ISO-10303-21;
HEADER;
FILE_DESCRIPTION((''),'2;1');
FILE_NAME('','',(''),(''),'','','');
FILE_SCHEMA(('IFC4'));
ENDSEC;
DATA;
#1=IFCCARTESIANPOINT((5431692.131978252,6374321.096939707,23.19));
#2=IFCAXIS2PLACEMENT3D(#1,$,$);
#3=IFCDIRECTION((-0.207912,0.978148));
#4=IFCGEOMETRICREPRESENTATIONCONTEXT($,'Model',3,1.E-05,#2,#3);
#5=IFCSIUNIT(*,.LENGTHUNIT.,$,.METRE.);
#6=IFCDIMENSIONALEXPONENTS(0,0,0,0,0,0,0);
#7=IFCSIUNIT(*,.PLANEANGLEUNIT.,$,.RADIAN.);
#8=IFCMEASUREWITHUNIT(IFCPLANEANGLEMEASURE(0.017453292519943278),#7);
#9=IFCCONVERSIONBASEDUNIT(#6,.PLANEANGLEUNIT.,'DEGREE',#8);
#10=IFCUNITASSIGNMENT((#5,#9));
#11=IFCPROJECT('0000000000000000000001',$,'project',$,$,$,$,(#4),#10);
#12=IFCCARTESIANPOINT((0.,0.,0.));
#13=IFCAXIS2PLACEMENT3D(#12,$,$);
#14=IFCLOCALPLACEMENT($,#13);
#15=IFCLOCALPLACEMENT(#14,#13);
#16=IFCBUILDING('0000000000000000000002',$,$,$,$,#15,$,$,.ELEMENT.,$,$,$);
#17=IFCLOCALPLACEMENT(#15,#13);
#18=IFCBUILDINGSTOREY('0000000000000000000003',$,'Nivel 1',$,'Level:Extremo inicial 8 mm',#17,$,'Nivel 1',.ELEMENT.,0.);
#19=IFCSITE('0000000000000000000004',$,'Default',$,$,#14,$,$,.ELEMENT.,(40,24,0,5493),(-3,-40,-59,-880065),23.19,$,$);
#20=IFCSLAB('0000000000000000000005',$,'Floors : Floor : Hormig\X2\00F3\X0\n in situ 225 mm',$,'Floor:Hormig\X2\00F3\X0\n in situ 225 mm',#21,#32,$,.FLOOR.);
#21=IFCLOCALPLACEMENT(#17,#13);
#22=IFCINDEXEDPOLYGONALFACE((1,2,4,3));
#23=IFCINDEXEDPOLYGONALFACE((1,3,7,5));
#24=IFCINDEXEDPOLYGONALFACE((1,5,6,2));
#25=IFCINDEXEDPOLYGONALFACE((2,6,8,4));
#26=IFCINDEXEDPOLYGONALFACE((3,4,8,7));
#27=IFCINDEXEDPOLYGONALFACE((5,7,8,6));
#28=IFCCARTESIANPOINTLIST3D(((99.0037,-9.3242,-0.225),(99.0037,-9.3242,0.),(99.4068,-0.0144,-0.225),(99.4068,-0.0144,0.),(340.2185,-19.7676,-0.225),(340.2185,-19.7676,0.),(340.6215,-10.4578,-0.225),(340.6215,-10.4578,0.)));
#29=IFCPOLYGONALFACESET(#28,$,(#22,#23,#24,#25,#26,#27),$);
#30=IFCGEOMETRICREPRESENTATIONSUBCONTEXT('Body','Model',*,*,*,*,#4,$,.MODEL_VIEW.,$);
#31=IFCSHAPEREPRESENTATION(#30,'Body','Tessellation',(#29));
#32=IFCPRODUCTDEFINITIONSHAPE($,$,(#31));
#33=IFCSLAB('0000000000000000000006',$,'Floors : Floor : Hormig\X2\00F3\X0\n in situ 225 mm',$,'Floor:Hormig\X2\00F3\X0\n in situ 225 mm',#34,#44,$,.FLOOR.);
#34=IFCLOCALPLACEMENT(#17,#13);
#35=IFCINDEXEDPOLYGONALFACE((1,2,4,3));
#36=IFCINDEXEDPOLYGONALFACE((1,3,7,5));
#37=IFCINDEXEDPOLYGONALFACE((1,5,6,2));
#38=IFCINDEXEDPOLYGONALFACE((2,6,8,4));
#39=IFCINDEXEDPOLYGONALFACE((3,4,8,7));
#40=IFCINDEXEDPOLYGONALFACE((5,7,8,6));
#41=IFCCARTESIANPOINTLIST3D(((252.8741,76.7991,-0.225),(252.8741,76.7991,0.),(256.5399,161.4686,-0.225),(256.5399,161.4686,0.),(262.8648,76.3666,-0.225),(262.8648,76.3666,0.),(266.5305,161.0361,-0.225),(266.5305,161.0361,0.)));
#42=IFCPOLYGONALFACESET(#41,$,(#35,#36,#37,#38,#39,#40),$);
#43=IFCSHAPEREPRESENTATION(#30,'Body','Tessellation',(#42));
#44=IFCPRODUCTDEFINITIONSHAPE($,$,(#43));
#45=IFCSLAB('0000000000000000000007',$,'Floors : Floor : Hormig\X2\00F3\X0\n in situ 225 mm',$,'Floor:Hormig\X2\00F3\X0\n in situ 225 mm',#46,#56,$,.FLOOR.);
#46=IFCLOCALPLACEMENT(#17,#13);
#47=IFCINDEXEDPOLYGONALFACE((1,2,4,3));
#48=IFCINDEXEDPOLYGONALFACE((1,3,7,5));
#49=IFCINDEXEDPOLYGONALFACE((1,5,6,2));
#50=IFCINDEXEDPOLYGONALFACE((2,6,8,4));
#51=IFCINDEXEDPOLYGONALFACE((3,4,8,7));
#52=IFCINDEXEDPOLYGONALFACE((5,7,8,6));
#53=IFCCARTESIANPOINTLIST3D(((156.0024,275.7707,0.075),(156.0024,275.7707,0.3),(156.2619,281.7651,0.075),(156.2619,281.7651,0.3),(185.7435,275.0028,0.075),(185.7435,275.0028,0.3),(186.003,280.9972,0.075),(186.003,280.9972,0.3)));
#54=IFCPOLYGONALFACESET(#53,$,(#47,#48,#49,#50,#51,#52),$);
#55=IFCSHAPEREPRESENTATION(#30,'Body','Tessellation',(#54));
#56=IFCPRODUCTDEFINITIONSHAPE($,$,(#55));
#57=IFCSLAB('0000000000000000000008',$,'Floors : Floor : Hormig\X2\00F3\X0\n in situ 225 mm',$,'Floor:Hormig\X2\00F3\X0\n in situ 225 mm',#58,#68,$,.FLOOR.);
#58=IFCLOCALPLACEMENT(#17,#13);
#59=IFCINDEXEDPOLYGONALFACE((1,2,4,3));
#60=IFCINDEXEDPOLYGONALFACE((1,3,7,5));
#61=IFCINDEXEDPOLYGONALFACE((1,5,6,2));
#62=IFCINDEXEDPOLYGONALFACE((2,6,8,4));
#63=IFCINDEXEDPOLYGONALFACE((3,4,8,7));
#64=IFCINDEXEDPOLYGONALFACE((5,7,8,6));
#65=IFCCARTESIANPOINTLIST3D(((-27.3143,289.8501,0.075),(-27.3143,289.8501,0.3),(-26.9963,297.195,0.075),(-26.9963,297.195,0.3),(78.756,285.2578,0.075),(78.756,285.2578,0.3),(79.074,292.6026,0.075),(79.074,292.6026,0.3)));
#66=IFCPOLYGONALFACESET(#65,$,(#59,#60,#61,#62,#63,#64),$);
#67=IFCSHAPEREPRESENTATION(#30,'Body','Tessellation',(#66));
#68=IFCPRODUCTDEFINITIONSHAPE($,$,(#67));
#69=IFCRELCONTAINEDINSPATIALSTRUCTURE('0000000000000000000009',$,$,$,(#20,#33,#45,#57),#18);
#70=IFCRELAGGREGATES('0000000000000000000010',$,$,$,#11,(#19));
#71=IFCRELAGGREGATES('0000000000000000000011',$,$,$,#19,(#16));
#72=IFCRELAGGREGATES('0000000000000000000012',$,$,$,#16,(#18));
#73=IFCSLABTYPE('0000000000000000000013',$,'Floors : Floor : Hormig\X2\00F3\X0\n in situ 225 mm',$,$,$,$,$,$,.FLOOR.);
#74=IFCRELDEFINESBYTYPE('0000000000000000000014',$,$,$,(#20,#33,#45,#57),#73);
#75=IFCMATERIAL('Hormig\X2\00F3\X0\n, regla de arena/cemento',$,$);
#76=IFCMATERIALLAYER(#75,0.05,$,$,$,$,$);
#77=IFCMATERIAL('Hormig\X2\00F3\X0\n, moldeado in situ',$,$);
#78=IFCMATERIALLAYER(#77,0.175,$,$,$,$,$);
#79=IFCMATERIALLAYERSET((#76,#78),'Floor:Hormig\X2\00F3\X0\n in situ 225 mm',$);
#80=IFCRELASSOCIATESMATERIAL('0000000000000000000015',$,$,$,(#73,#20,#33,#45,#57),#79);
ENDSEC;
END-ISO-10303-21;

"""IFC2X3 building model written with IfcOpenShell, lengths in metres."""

from ifc_helpers import new_model, entity, si_unit, converted_unit, direction, frame, frame_2d, origin, place, context, subcontext, project, spatial, polyline, rectangle, outline, extrude, material, layer, layer_set, layer_usage, type_object, element, save


model = new_model("IFC2X3")

# Units and contexts
model_context = context("Model", 3, precision=1e-05, world=frame((5431692.131978252, 6374321.096939707, 23.19)), true_north=direction((-0.207912, 0.978148)))
body_context = subcontext(model_context, "Body", "Model", "MODEL_VIEW")
ifc_project = project(units=[si_unit("LENGTHUNIT", "METRE"), converted_unit("PLANEANGLEUNIT", "DEGREE", entity("IfcPlaneAngleMeasure", 0.017453292519943278), si_unit("PLANEANGLEUNIT", "RADIAN"), dimensions=[0, 0, 0, 0, 0, 0, 0])], contexts=[model_context])

# Site, building, storey
site_placement = place(None, origin())
site = spatial("IfcSite", under=ifc_project, at=site_placement, Name="Default", CompositionType="ELEMENT", RefLatitude=(40, 24, 0, 5493), RefLongitude=(-3, -40, -59, -880065), RefElevation=23.19)
building_placement = place(site_placement, origin())
building = spatial("IfcBuilding", under=site, at=building_placement, CompositionType="ELEMENT")
storey_placement = place(building_placement, origin())
storey = spatial("IfcBuildingStorey", under=building, at=storey_placement, Name="Nivel 1", ObjectType="Level:Extremo inicial 8 mm", LongName="Nivel 1", CompositionType="ELEMENT", Elevation=0.0)

# Slabs
ifc_material_1 = material(Name="Hormigón, regla de arena/cemento")
ifc_layer_1 = layer(ifc_material_1, 0.05)
ifc_material_2 = material(Name="Hormigón, moldeado in situ")
ifc_layer_2 = layer(ifc_material_2, 0.175)
ifc_layer_set = layer_set([ifc_layer_1, ifc_layer_2], Name="Floor:Hormigón in situ 225 mm")
slab_type = type_object("IfcSlabType", Name="Floors : Floor : Hormigón in situ 225 mm", PredefinedType="FLOOR", material=ifc_layer_set)
ifc_layer_usage_1 = layer_usage(ifc_layer_set, "AXIS3", "POSITIVE", 0.0)
slab_1_placement = place(storey_placement, origin())
element("IfcSlab", 1, at=slab_1_placement, inside=storey, type_object=slab_type, material=ifc_layer_usage_1, Name="Floors : Floor : Hormigón in situ 225 mm", ObjectType="Floor:Hormigón in situ 225 mm", PredefinedType="FLOOR", context=body_context, shape_type="SweptSolid", body=[
    extrude(rectangle(XDim=241.4407, YDim=9.3185, at=frame_2d((0.0, 0.0), x_axis=(1.0, 0.0))), frame((219.8126, -9.891, 0.0), z_axis=(0.0, 0.0, -1.0), x_axis=(0.999064, -0.043255, 0.0)), (0.0, 0.0, 1.0), 0.225),
])
ifc_layer_usage_2 = layer_usage(ifc_layer_set, "AXIS3", "POSITIVE", 0.0)
slab_2_placement = place(storey_placement, origin())
element("IfcSlab", 2, at=slab_2_placement, inside=storey, type_object=slab_type, material=ifc_layer_usage_2, Name="Floors : Floor : Hormigón in situ 225 mm", ObjectType="Floor:Hormigón in situ 225 mm", PredefinedType="FLOOR", context=body_context, shape_type="SweptSolid", body=[
    extrude(rectangle(XDim=10.0, YDim=84.7488, at=frame_2d((0.0, 0.0), x_axis=(1.0, 0.0))), frame((259.7023, 118.9176, 0.0), z_axis=(0.0, 0.0, -1.0), x_axis=(0.999064, -0.043255, 0.0)), (0.0, 0.0, 1.0), 0.225),
])
ifc_layer_usage_3 = layer_usage(ifc_layer_set, "AXIS3", "POSITIVE", 0.0)
slab_3_placement = place(storey_placement, origin())
element("IfcSlab", 3, at=slab_3_placement, inside=storey, type_object=slab_type, material=ifc_layer_usage_3, Name="Floors : Floor : Hormigón in situ 225 mm", ObjectType="Floor:Hormigón in situ 225 mm", PredefinedType="FLOOR", context=body_context, shape_type="SweptSolid", body=[
    extrude(outline(polyline([(-14.8231, -2.9995), (14.9279, -2.9995), (14.8231, 2.9995), (-14.9279, 2.9995), (-14.8231, -2.9995)])), frame((171.0027, 278.3839, 0.3), z_axis=(0.0, 0.0, -1.0), x_axis=(0.999667, -0.025812, 0.0)), (0.0, 0.0, 1.0), 0.225),
])
ifc_layer_usage_4 = layer_usage(ifc_layer_set, "AXIS3", "POSITIVE", 0.0)
slab_4_placement = place(storey_placement, origin())
element("IfcSlab", 4, at=slab_4_placement, inside=storey, type_object=slab_type, material=ifc_layer_usage_4, Name="Floors : Floor : Hormigón in situ 225 mm", ObjectType="Floor:Hormigón in situ 225 mm", PredefinedType="FLOOR", context=body_context, shape_type="SweptSolid", body=[
    extrude(rectangle(XDim=106.1696, YDim=7.3517, at=frame_2d((0.0, 0.0), x_axis=(1.0, 0.0))), frame((25.8799, 291.2264, 0.3), z_axis=(0.0, 0.0, -1.0), x_axis=(0.999064, -0.043255, 0.0)), (0.0, 0.0, 1.0), 0.225),
])

save(model, "model.ifc")
